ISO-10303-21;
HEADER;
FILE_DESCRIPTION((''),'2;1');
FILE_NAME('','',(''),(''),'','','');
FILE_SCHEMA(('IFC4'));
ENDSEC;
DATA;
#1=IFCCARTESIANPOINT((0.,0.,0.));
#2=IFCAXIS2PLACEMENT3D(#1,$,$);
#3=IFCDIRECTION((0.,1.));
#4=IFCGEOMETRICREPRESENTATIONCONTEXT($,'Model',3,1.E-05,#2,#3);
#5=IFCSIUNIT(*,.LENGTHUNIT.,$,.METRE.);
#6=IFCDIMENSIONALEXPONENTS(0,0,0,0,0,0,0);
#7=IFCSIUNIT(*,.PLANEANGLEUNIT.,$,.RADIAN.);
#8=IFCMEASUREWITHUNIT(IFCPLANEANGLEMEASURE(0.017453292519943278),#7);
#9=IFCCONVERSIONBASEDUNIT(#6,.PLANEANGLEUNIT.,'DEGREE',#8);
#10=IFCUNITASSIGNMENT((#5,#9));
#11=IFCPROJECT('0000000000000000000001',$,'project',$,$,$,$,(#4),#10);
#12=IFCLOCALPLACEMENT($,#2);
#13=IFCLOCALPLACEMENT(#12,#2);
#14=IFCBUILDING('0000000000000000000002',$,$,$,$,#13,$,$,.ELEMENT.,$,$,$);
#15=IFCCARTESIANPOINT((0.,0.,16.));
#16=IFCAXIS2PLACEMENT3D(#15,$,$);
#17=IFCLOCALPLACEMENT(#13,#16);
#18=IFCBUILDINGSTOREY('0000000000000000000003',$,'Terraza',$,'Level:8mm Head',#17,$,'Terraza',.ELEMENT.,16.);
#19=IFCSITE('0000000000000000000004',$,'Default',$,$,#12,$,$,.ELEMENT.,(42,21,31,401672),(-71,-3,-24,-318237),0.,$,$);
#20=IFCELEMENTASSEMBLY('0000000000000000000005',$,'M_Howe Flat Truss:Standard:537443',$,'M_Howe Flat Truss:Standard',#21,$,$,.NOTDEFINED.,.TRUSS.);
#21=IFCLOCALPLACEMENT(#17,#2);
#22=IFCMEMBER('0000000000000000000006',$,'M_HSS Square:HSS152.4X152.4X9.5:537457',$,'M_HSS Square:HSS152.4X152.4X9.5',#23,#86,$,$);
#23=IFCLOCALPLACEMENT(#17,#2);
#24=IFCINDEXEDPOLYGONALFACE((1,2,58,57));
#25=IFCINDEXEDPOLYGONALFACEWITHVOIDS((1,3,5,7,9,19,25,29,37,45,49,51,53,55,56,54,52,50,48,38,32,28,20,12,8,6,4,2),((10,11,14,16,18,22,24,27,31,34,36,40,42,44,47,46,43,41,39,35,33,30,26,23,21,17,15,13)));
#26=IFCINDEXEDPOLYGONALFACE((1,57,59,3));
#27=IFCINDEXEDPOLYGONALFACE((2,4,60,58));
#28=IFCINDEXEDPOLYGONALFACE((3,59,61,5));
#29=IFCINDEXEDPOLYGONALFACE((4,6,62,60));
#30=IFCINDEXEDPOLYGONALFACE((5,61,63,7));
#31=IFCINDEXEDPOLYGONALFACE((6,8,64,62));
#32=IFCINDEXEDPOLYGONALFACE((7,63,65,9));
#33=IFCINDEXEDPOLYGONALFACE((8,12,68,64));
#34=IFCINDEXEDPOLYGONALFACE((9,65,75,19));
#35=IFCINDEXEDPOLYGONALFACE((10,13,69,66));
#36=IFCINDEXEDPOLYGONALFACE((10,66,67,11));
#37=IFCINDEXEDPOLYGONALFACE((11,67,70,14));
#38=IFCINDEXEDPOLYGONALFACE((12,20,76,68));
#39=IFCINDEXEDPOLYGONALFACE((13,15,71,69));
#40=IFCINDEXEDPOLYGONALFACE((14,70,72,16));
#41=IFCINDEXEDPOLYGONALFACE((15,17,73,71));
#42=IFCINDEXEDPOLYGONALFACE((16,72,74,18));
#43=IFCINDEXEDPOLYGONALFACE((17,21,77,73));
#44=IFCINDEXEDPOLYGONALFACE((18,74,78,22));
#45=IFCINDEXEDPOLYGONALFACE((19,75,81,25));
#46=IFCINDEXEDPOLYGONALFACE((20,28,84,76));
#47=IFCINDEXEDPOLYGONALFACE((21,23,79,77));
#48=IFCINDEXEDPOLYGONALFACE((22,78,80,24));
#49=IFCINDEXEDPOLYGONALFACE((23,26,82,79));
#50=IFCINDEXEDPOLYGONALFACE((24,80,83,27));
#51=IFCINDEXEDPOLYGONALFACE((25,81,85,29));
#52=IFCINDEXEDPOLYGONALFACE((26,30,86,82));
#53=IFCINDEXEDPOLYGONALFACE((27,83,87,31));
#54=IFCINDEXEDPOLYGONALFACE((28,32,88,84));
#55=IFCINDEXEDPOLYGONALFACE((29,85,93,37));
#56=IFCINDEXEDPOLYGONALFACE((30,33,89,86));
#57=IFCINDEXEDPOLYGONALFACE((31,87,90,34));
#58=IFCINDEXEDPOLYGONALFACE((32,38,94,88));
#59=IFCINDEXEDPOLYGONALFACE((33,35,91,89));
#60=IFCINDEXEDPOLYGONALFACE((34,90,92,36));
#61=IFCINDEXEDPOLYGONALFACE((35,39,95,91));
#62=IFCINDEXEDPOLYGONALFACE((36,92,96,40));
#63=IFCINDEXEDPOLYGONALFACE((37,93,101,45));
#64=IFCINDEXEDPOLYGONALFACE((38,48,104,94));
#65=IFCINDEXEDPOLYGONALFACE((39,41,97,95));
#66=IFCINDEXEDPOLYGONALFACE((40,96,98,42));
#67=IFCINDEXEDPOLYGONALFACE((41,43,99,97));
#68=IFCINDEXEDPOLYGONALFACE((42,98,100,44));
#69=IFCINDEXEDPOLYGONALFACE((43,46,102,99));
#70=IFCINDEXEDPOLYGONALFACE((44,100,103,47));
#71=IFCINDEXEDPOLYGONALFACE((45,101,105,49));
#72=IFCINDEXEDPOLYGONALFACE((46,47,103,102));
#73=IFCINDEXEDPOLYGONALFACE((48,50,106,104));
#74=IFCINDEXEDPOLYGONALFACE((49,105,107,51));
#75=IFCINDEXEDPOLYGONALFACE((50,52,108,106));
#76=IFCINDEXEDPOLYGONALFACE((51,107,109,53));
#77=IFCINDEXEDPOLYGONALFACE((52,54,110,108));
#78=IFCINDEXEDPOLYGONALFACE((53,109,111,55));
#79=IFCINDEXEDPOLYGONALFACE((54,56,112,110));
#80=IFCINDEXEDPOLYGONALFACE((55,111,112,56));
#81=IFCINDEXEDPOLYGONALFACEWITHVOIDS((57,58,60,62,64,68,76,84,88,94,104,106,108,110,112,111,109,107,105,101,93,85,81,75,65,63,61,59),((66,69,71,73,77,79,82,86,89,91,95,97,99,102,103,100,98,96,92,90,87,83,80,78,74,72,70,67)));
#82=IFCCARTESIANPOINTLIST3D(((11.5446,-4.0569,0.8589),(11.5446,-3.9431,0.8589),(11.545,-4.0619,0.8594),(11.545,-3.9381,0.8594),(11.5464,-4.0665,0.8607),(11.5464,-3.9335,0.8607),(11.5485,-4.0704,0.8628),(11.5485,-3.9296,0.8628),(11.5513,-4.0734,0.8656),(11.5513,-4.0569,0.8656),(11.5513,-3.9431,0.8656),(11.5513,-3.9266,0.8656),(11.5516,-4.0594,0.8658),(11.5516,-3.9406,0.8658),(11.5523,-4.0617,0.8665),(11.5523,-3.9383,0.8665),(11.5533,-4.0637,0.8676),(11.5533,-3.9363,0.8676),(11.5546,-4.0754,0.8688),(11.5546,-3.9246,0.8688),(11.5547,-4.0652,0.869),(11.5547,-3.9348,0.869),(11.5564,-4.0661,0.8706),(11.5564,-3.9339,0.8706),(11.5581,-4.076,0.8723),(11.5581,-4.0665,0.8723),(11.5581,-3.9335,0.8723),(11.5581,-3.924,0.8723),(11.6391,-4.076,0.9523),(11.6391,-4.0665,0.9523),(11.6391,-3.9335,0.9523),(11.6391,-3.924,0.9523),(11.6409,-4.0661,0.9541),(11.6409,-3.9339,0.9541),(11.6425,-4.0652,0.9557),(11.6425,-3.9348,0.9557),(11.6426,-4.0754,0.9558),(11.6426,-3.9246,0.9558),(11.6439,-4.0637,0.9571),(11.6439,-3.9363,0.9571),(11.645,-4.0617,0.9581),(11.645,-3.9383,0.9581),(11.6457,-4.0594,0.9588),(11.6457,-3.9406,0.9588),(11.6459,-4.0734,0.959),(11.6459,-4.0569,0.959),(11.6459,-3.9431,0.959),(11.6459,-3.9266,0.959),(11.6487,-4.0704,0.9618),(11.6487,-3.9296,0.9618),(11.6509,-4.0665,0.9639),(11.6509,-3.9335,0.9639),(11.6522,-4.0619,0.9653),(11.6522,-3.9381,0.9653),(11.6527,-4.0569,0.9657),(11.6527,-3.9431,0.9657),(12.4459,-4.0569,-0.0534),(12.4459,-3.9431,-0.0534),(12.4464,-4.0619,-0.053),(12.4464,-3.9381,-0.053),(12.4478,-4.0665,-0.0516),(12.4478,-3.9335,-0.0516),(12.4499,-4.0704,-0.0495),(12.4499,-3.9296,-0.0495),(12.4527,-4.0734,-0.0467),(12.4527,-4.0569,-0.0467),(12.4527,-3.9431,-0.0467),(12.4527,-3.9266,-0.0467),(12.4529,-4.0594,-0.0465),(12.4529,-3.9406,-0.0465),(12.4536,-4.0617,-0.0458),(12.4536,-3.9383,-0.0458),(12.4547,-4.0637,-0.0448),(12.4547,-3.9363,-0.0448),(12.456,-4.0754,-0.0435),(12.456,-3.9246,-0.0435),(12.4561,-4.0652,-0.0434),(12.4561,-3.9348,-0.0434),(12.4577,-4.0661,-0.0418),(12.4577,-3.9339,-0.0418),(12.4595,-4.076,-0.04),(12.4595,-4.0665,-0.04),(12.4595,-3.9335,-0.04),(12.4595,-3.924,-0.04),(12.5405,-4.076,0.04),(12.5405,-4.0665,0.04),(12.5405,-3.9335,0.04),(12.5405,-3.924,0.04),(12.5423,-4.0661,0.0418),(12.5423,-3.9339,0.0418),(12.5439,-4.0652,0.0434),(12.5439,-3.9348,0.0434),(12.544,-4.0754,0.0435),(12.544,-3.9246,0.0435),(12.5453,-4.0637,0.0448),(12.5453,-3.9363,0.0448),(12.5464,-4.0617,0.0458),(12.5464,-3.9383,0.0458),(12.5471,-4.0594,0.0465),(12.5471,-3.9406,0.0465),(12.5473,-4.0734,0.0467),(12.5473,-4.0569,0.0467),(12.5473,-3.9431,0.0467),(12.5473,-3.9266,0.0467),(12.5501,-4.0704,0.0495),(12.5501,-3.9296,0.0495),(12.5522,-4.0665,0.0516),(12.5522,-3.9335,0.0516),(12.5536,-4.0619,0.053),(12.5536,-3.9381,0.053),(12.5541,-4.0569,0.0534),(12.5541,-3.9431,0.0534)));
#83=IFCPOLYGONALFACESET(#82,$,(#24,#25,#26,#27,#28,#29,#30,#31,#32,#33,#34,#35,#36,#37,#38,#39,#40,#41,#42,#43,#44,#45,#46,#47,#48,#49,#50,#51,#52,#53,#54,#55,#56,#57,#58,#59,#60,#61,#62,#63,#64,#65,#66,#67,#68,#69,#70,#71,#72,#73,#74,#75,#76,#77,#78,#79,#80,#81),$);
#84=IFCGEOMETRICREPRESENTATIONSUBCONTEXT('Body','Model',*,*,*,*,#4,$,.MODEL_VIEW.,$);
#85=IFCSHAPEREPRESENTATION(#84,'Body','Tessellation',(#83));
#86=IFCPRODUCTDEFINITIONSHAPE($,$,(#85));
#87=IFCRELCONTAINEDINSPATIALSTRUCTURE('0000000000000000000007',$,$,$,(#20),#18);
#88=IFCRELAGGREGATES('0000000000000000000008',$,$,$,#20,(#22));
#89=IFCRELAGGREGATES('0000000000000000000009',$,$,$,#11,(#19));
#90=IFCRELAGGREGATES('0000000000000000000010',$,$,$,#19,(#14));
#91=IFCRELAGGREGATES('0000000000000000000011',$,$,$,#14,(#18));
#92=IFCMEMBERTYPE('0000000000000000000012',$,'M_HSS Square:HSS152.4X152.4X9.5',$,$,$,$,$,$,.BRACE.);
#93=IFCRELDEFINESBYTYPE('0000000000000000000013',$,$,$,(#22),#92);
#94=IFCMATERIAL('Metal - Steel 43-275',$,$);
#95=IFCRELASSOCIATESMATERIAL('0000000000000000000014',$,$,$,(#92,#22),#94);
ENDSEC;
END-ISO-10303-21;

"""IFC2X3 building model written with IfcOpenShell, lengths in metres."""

from ifc_helpers import new_model, entity, si_unit, converted_unit, direction, frame, frame_2d, origin, place, context, subcontext, project, spatial, polyline, circle_curve, parameter, trimmed, segment, composite_curve, outline, extrude, source, transform, mapped, material, type_object, type_shapes, element, aggregate, save


model = new_model("IFC2X3")

# Units and contexts
model_context = context("Model", 3, precision=1e-05, world=origin(), true_north=direction((0.0, 1.0)))
body_context = subcontext(model_context, "Body", "Model", "MODEL_VIEW")
ifc_project = project(units=[si_unit("LENGTHUNIT", "METRE"), converted_unit("PLANEANGLEUNIT", "DEGREE", entity("IfcPlaneAngleMeasure", 0.017453292519943278), si_unit("PLANEANGLEUNIT", "RADIAN"), dimensions=[0, 0, 0, 0, 0, 0, 0])], contexts=[model_context])

# Site, building, storey
site_placement = place(None, origin())
site = spatial("IfcSite", under=ifc_project, at=site_placement, Name="Default", CompositionType="ELEMENT", RefLatitude=(42, 21, 31, 401672), RefLongitude=(-71, -3, -24, -318237), RefElevation=0.0)
building_placement = place(site_placement, origin())
building = spatial("IfcBuilding", under=site, at=building_placement, CompositionType="ELEMENT")
storey_placement = place(building_placement, frame((0.0, 0.0, 16.0)))
storey = spatial("IfcBuildingStorey", under=building, at=storey_placement, Name="Terraza", ObjectType="Level:8mm Head", LongName="Terraza", CompositionType="ELEMENT", Elevation=16.0)

# Shared definitions
ifc_material = material(Name="Metal - Steel 43-275")

# Element assembly
assembly_1_placement = place(storey_placement, origin())
assembly_1 = element("IfcElementAssembly", 1, at=assembly_1_placement, inside=storey, Name="M_Howe Flat Truss:Standard:537443", ObjectType="M_Howe Flat Truss:Standard", AssemblyPlace="NOTDEFINED", PredefinedType="TRUSS")

# Member
member_type_1 = type_object("IfcMemberType", Name="M_HSS Square:HSS152.4X152.4X9.5", PredefinedType="BRACE", material=ifc_material)
shared_shape_1 = source(origin(), body_context, "Body", "SweptSolid", [
    extrude(outline(composite_curve([segment(polyline([(-0.0569, -0.076), (0.0569, -0.076)]), True, "CONTINUOUS"), segment(trimmed(circle_curve(frame_2d((0.0569, -0.0569), x_axis=(0.0, 1.0)), 0.0191), [parameter(180.0)], [parameter(270.0)], True, "PARAMETER"), True, "CONTINUOUS"), segment(polyline([(0.076, -0.0569), (0.076, 0.0569)]), True, "CONTINUOUS"), segment(trimmed(circle_curve(frame_2d((0.0569, 0.0569), x_axis=(0.0, 1.0)), 0.0191), [parameter(270.0)], [parameter(0.0)], True, "PARAMETER"), True, "CONTINUOUS"), segment(polyline([(0.0569, 0.076), (-0.0569, 0.076)]), True, "CONTINUOUS"), segment(trimmed(circle_curve(frame_2d((-0.0569, 0.0569), x_axis=(0.0, 1.0)), 0.0191), [parameter(0.0)], [parameter(90.0)], True, "PARAMETER"), True, "CONTINUOUS"), segment(polyline([(-0.076, 0.0569), (-0.076, -0.0569)]), True, "CONTINUOUS"), segment(trimmed(circle_curve(frame_2d((-0.0569, -0.0569), x_axis=(0.0, 1.0)), 0.0191), [parameter(90.0)], [parameter(180.0)], True, "PARAMETER"), True, "CONTINUOUS")], self_intersect=False), holes=[composite_curve([segment(trimmed(circle_curve(frame_2d((-0.0569, 0.0569), x_axis=(0.0, 1.0)), 0.0095), [parameter(360.0)], [parameter(90.0)], True, "PARAMETER"), False, "CONTINUOUS"), segment(polyline([(-0.0569, 0.0665), (0.0569, 0.0665)]), True, "CONTINUOUS"), segment(trimmed(circle_curve(frame_2d((0.0569, 0.0569), x_axis=(0.0, 1.0)), 0.0095), [parameter(270.0)], [parameter(360.0)], True, "PARAMETER"), False, "CONTINUOUS"), segment(polyline([(0.0665, 0.0569), (0.0665, -0.0569)]), True, "CONTINUOUS"), segment(trimmed(circle_curve(frame_2d((0.0569, -0.0569), x_axis=(0.0, 1.0)), 0.0095), [parameter(180.0)], [parameter(270.0)], True, "PARAMETER"), False, "CONTINUOUS"), segment(polyline([(0.0569, -0.0665), (-0.0569, -0.0665)]), True, "CONTINUOUS"), segment(trimmed(circle_curve(frame_2d((-0.0569, -0.0569), x_axis=(0.0, 1.0)), 0.0095), [parameter(90.0)], [parameter(180.0)], True, "PARAMETER"), False, "CONTINUOUS"), segment(polyline([(-0.0665, -0.0569), (-0.0665, 0.0569)]), True, "CONTINUOUS")], self_intersect=False)]), frame((-0.5357, 0.0, 0.0), z_axis=(1.0, 0.0, 0.0), x_axis=(0.0, 0.0, -1.0)), (0.0, 0.0, 1.0), 1.2825),
])
type_shapes(member_type_1, [shared_shape_1])
member_1_placement = place(assembly_1_placement, frame((11.9751, -4.0, 0.5312), z_axis=(-0.711368, 0.0, -0.702819), x_axis=(0.702819, 0.0, -0.711368)))
member_1 = element("IfcMember", 2, at=member_1_placement, type_object=member_type_1, material=ifc_material, Name="M_HSS Square:HSS152.4X152.4X9.5:537457", ObjectType="M_HSS Square:HSS152.4X152.4X9.5", context=body_context, shape_type="MappedRepresentation", body=[
    mapped(shared_shape_1, transform((0.0, 0.0, 0.0), scale=1.0)),
])
aggregate(assembly_1, [member_1])

save(model, "model.ifc")
